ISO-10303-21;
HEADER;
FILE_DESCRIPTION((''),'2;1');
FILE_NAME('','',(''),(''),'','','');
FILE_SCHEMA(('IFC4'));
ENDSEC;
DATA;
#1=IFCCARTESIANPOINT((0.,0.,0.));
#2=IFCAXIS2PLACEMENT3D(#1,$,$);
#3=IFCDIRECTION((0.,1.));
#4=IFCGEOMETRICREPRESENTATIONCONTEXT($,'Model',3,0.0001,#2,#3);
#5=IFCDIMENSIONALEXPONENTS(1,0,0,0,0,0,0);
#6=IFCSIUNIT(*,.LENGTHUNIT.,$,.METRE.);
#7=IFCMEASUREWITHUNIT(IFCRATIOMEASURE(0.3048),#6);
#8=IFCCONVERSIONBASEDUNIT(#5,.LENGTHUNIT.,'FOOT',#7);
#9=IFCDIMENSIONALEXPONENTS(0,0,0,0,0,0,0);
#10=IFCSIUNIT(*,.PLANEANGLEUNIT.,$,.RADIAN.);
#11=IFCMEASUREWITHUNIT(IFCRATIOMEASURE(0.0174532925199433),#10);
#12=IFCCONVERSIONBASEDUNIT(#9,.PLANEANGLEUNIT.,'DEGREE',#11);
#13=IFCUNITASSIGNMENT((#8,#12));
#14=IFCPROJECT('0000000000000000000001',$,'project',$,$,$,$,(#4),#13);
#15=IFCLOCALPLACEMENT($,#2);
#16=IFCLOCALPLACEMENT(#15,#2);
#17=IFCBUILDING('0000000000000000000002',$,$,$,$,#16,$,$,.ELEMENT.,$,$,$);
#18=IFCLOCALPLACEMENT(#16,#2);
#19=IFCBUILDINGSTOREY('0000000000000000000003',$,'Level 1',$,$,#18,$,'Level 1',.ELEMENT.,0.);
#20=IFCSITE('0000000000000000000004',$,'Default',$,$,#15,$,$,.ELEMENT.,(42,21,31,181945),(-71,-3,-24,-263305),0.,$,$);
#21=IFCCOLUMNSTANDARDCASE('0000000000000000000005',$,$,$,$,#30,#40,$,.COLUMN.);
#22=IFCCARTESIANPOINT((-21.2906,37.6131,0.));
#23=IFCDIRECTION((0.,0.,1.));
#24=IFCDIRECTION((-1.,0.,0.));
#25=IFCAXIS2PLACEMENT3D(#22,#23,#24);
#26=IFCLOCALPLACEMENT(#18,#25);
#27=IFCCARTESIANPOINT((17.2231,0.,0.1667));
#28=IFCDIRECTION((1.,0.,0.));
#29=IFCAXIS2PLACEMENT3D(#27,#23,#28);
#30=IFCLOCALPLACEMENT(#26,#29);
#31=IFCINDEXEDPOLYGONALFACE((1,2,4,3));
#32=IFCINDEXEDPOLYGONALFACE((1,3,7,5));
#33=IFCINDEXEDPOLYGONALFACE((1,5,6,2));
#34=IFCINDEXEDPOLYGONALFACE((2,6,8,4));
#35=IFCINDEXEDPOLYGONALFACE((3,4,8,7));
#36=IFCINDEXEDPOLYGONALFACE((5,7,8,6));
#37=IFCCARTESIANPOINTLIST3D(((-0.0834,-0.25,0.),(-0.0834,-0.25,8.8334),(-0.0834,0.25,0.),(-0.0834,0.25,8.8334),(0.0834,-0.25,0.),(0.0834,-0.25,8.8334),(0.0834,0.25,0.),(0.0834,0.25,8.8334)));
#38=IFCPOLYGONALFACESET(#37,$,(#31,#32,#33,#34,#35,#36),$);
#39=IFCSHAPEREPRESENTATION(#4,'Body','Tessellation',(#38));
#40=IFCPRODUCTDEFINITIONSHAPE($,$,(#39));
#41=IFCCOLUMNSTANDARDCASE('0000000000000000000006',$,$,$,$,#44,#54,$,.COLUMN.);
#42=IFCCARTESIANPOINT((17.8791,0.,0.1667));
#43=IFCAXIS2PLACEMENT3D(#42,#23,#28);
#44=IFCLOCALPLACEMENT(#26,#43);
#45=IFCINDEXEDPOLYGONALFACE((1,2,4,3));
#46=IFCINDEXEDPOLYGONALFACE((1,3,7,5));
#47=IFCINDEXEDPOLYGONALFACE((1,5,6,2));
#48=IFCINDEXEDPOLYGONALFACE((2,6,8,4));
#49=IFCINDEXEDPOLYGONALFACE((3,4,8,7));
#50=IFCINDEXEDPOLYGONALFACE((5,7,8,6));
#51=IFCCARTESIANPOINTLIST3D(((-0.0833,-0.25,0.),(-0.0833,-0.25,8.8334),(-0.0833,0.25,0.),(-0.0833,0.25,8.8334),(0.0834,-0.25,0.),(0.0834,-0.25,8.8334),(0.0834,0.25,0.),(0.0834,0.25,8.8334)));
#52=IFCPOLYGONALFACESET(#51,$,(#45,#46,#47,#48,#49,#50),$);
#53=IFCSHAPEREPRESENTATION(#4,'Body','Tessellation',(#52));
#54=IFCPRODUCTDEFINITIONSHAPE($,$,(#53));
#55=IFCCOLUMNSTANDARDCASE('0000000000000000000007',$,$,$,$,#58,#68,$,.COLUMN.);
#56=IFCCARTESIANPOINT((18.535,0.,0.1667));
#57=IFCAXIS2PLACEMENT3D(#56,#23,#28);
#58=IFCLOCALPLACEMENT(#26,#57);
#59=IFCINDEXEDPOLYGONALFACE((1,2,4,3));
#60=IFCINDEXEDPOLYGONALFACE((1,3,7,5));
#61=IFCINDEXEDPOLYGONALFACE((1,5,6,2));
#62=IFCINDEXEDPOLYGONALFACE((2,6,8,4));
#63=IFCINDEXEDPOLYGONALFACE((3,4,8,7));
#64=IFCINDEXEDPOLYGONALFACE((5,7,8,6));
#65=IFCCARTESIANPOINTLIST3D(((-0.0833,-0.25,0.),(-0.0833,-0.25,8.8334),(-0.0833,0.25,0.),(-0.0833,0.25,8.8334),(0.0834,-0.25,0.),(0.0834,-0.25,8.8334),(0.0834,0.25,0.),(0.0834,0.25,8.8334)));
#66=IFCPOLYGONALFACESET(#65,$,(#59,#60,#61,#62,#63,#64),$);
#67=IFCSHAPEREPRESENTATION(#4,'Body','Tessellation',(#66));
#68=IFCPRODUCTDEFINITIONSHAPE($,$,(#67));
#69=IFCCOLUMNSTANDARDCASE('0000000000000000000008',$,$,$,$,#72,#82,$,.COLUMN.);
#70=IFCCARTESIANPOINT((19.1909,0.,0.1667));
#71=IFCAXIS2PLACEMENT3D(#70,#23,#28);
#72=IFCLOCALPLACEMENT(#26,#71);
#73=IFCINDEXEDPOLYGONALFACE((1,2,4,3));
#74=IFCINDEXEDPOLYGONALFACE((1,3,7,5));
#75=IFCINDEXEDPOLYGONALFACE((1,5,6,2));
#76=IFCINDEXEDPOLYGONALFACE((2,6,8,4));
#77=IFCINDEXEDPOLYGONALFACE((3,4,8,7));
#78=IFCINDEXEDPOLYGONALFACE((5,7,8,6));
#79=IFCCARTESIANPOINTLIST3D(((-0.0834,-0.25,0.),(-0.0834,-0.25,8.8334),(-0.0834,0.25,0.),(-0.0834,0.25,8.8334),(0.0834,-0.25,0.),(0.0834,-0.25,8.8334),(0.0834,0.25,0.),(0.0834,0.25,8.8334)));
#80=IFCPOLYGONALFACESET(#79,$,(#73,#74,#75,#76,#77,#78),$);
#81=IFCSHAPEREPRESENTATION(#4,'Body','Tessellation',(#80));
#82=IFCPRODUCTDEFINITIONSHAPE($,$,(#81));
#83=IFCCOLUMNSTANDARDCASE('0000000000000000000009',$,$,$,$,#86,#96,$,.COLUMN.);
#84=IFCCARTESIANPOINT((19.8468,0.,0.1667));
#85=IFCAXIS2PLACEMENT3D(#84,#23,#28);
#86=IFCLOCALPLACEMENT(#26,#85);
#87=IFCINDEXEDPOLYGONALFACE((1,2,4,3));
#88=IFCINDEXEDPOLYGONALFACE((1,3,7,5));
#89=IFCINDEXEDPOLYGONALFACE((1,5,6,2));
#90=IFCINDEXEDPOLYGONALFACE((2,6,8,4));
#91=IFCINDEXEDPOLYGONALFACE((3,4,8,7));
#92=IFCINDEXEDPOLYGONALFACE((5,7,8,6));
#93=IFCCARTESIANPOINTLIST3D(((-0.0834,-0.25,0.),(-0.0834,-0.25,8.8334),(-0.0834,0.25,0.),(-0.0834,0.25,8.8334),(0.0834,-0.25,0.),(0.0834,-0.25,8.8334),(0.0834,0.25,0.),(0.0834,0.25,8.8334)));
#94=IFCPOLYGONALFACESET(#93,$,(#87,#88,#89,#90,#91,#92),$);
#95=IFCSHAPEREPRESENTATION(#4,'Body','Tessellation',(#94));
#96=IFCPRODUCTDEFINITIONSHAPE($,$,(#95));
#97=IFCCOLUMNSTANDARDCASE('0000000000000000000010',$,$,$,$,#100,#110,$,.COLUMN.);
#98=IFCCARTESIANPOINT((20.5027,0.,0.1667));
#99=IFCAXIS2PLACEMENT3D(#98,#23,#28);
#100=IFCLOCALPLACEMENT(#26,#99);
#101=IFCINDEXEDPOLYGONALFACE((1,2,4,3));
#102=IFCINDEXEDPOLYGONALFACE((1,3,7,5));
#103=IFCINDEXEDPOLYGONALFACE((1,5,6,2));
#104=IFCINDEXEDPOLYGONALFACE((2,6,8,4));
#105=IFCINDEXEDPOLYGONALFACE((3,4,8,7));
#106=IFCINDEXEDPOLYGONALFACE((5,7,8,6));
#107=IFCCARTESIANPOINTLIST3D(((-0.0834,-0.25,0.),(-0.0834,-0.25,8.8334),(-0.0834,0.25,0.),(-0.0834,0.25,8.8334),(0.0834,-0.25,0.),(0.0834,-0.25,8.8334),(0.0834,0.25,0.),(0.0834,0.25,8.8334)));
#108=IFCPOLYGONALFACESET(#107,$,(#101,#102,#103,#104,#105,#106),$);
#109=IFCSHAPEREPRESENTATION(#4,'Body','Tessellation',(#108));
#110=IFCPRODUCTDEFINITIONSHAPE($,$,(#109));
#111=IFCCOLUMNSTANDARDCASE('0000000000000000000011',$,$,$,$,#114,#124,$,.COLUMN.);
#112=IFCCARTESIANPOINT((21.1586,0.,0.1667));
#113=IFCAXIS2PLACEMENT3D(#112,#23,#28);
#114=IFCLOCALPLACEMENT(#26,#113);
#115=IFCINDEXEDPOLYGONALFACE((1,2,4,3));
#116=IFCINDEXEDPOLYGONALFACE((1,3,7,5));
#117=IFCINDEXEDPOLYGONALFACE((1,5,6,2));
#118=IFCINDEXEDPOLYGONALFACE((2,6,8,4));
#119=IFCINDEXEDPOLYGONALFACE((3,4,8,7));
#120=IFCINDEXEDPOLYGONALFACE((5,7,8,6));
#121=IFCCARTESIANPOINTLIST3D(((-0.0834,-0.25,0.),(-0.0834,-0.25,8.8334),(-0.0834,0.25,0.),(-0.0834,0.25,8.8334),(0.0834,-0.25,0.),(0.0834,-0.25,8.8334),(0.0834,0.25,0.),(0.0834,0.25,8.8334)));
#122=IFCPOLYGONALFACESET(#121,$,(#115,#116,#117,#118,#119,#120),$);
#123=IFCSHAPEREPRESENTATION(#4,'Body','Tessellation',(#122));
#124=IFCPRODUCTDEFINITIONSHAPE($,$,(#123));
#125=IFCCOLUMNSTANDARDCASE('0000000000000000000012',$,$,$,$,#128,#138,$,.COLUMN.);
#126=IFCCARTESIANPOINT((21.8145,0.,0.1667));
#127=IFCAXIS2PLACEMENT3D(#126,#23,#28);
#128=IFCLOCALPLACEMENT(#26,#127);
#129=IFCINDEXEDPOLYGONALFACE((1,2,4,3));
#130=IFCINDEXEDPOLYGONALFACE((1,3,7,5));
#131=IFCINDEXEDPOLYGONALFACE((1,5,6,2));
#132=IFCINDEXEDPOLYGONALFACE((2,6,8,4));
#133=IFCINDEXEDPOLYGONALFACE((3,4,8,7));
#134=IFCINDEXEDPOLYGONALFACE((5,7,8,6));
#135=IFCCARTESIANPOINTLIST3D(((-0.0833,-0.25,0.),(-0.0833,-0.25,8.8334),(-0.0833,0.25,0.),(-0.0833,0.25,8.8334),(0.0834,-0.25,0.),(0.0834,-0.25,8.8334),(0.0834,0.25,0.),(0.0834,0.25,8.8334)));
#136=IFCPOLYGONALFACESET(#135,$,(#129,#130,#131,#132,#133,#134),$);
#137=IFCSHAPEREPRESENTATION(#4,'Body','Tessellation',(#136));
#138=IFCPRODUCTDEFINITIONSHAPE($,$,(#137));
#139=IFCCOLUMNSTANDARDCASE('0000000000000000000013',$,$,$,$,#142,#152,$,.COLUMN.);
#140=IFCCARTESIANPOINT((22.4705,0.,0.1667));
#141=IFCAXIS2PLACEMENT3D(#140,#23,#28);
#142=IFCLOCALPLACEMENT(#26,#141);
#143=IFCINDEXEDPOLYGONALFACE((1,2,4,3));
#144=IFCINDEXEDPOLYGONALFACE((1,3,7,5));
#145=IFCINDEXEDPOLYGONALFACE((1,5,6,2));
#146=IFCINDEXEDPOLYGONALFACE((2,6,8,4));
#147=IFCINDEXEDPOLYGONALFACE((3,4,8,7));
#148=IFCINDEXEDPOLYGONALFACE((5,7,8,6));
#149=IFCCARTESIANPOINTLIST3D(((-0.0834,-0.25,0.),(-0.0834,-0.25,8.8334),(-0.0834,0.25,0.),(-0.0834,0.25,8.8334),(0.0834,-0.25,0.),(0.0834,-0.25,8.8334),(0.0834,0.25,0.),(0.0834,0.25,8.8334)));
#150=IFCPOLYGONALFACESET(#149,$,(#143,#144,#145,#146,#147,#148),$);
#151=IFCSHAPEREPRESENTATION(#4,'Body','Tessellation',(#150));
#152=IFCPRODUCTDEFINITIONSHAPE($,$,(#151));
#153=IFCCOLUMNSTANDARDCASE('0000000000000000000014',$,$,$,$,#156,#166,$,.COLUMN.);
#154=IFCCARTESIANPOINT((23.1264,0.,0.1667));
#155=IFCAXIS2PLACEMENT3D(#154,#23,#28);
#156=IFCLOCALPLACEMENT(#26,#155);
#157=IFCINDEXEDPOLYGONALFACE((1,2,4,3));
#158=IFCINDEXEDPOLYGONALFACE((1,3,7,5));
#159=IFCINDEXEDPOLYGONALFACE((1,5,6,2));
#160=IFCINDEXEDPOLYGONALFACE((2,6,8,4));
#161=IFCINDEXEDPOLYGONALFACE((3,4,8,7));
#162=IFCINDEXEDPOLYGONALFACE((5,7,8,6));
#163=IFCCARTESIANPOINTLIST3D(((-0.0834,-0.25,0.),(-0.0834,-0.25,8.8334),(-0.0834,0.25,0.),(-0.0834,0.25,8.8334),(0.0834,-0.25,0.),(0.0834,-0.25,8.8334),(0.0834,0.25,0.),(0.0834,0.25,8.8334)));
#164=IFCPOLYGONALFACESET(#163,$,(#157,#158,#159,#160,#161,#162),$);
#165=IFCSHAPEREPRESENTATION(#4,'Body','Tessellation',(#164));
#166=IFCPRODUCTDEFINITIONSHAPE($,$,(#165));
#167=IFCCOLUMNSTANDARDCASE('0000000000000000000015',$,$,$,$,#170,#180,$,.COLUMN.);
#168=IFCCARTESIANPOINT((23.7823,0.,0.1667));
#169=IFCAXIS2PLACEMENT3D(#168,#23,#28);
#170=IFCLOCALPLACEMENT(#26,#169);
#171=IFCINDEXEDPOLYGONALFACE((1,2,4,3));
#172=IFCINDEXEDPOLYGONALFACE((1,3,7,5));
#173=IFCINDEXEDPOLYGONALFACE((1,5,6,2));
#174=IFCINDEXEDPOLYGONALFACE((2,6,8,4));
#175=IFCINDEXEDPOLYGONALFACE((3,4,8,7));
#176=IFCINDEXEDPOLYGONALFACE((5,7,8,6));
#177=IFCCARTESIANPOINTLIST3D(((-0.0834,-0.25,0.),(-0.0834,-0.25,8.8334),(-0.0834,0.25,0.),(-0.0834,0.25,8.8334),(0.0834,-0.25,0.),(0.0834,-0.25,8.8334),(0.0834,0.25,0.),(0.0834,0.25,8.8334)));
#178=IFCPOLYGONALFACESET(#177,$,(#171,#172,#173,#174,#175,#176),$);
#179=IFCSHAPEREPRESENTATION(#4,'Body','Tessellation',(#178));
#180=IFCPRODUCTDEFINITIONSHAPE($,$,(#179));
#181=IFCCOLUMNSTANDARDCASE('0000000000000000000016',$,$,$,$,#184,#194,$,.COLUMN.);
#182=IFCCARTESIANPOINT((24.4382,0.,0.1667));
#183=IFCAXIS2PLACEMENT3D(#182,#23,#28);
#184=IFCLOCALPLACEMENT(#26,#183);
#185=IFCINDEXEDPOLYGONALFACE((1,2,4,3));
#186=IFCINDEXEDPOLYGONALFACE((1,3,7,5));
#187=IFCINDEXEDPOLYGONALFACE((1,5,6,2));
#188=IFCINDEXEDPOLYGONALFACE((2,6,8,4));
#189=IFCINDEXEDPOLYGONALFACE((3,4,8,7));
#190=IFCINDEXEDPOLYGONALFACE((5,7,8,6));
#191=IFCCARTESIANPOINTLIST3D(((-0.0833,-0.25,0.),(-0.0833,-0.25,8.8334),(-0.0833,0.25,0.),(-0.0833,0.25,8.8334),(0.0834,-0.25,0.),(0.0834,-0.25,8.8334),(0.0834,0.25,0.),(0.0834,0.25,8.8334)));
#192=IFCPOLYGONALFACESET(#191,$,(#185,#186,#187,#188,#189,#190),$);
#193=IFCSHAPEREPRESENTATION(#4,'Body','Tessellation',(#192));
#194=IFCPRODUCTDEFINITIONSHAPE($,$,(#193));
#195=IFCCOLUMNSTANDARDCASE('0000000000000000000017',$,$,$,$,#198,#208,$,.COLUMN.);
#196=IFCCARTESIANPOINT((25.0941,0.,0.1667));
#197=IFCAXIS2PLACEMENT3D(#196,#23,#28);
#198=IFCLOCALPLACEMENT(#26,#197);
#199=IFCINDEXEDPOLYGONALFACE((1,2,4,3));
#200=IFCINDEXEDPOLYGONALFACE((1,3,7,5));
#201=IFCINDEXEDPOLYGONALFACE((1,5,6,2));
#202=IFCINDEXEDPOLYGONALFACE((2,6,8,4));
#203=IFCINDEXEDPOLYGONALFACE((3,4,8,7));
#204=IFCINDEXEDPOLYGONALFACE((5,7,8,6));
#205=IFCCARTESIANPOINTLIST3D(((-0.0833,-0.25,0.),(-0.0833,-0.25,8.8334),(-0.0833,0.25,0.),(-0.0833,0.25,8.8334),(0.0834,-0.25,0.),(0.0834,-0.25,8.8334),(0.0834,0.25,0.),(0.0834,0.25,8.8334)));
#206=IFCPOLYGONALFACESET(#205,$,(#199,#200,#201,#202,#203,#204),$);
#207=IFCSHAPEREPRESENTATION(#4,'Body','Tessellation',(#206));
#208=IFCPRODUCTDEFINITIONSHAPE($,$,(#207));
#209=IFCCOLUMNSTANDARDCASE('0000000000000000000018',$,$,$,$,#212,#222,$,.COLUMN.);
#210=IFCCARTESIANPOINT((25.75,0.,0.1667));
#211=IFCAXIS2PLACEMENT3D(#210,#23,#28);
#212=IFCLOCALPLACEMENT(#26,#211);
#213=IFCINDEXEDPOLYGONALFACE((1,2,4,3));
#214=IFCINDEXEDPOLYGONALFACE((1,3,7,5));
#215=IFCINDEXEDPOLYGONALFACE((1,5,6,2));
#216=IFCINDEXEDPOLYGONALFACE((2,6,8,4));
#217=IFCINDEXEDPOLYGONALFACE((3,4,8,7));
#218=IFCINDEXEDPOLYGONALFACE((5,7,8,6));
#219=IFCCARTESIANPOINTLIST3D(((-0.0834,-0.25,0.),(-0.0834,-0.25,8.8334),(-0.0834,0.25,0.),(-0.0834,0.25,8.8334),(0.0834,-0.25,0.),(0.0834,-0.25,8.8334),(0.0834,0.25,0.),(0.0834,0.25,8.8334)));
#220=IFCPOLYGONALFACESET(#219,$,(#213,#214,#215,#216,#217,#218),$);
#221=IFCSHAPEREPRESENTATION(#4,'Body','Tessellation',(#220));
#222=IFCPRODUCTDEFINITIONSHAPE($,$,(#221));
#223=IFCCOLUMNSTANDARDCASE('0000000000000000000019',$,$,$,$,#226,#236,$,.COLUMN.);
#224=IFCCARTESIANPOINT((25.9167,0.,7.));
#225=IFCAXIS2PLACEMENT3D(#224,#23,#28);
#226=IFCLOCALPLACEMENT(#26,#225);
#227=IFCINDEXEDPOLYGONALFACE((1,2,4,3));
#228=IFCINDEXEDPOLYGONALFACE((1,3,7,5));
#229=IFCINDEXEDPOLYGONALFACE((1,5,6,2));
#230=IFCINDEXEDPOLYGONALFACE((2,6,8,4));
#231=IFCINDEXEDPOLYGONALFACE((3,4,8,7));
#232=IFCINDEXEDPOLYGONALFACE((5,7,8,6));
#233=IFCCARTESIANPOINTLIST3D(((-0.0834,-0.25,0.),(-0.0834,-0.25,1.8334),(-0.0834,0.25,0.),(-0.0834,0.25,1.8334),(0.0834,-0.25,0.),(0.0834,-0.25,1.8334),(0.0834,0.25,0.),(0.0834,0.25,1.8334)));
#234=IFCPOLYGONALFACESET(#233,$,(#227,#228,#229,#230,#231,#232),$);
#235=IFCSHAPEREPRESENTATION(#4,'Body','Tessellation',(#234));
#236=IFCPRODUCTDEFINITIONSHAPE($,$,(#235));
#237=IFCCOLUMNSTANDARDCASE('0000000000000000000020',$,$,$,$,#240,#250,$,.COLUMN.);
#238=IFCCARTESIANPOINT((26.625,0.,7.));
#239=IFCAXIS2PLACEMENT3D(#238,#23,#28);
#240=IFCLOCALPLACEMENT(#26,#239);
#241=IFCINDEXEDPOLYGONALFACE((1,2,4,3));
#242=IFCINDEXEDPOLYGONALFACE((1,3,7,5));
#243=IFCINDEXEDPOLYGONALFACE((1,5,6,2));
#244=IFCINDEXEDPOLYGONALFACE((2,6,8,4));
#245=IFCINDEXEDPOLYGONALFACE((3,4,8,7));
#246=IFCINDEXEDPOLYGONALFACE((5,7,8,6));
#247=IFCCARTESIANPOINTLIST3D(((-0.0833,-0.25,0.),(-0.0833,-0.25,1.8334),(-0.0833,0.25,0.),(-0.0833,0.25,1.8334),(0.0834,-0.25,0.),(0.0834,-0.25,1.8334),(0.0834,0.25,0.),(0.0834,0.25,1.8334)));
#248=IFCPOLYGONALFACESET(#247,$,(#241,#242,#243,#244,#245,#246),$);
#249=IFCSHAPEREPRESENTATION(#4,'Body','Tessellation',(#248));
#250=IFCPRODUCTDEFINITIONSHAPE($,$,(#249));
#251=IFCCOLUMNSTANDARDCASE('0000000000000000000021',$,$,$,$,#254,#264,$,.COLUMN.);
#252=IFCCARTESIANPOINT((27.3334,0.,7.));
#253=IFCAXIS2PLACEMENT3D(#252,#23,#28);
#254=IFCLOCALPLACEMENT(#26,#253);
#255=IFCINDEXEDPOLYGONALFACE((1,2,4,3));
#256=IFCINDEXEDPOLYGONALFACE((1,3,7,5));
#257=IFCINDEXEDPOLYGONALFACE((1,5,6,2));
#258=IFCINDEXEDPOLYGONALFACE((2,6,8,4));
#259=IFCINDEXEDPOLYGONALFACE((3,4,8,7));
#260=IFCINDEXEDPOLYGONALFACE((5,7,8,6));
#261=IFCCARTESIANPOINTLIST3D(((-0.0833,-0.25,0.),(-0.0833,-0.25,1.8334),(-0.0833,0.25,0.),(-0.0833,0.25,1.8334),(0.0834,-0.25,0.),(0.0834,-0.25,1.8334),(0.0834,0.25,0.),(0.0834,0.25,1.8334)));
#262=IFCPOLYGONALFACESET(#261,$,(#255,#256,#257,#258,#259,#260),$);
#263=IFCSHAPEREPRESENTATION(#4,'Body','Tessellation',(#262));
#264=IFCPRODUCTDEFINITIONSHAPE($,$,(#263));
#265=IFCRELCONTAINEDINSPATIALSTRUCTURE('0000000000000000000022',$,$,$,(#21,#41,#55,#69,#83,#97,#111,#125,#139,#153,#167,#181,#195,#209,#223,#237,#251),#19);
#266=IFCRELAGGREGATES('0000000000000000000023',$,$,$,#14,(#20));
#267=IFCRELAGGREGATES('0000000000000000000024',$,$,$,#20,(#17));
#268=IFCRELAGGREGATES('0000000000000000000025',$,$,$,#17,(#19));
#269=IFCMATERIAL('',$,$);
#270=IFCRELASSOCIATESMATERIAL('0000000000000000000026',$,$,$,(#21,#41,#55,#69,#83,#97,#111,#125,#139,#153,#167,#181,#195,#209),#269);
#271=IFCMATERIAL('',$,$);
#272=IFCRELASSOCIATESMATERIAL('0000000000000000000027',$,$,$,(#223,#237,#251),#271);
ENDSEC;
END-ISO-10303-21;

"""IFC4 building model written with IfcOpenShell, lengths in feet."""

from ifc_helpers import new_model, entity, si_unit, converted_unit, direction, frame, origin, place, context, project, spatial, rectangle, extrude, material, element, save


model = new_model("IFC4")

# Units and contexts
model_context = context("Model", 3, precision=0.0001, world=origin(), true_north=direction((0.0, 1.0)))
ifc_project = project(units=[converted_unit("LENGTHUNIT", "FOOT", entity("IfcRatioMeasure", 0.3048), si_unit("LENGTHUNIT", "METRE"), dimensions=[1, 0, 0, 0, 0, 0, 0]), converted_unit("PLANEANGLEUNIT", "DEGREE", entity("IfcRatioMeasure", 0.0174532925199433), si_unit("PLANEANGLEUNIT", "RADIAN"), dimensions=[0, 0, 0, 0, 0, 0, 0])], contexts=[model_context])

# Site, building, storey
site_placement = place(None, origin())
site = spatial("IfcSite", under=ifc_project, at=site_placement, Name="Default", CompositionType="ELEMENT", RefLatitude=(42, 21, 31, 181945), RefLongitude=(-71, -3, -24, -263305), RefElevation=0.0)
building_placement = place(site_placement, origin())
building = spatial("IfcBuilding", under=site, at=building_placement, CompositionType="ELEMENT")
storey_placement = place(building_placement, origin())
storey = spatial("IfcBuildingStorey", under=building, at=storey_placement, Name="Level 1", LongName="Level 1", CompositionType="ELEMENT", Elevation=0.0)

# Columns
ifc_material_1 = material(Name="")
ifc_material_2 = material(Name="")
placement_1 = place(storey_placement, frame((-21.2906, 37.6131, 0.0), z_axis=(0.0, 0.0, 1.0), x_axis=(-1.0, 0.0, 0.0)))
for number, where, z_axis, x_axis in (
    (1, (17.2231, 0.0, 0.1667), (0.0, 0.0, 1.0), (1.0, 0.0, 0.0)),
    (2, (17.8791, 0.0, 0.1667), (0.0, 0.0, 1.0), (1.0, 0.0, 0.0)),
    (3, (18.535, 0.0, 0.1667), (0.0, 0.0, 1.0), (1.0, 0.0, 0.0)),
    (4, (19.1909, 0.0, 0.1667), (0.0, 0.0, 1.0), (1.0, 0.0, 0.0)),
    (5, (19.8468, 0.0, 0.1667), (0.0, 0.0, 1.0), (1.0, 0.0, 0.0)),
    (6, (20.5027, 0.0, 0.1667), (0.0, 0.0, 1.0), (1.0, 0.0, 0.0)),
    (7, (21.1586, 0.0, 0.1667), (0.0, 0.0, 1.0), (1.0, 0.0, 0.0)),
    (8, (21.8145, 0.0, 0.1667), (0.0, 0.0, 1.0), (1.0, 0.0, 0.0)),
    (9, (22.4705, 0.0, 0.1667), (0.0, 0.0, 1.0), (1.0, 0.0, 0.0)),
    (10, (23.1264, 0.0, 0.1667), (0.0, 0.0, 1.0), (1.0, 0.0, 0.0)),
    (11, (23.7823, 0.0, 0.1667), (0.0, 0.0, 1.0), (1.0, 0.0, 0.0)),
    (12, (24.4382, 0.0, 0.1667), (0.0, 0.0, 1.0), (1.0, 0.0, 0.0)),
    (13, (25.0941, 0.0, 0.1667), (0.0, 0.0, 1.0), (1.0, 0.0, 0.0)),
    (14, (25.75, 0.0, 0.1667), (0.0, 0.0, 1.0), (1.0, 0.0, 0.0)),
):
    element("IfcColumnStandardCase", number, at=place(placement_1, frame(where, z_axis=z_axis, x_axis=x_axis)), inside=storey, material=ifc_material_1, PredefinedType="COLUMN", context=model_context, shape_type="SweptSolid", body=[
        extrude(rectangle(XDim=0.1667, YDim=0.5), origin(), (0.0, 0.0, 1.0), 8.8334),
    ])
for number, where, z_axis, x_axis in (
    (15, (25.9167, 0.0, 7.0), (0.0, 0.0, 1.0), (1.0, 0.0, 0.0)),
    (16, (26.625, 0.0, 7.0), (0.0, 0.0, 1.0), (1.0, 0.0, 0.0)),
    (17, (27.3334, 0.0, 7.0), (0.0, 0.0, 1.0), (1.0, 0.0, 0.0)),
):
    element("IfcColumnStandardCase", number, at=place(placement_1, frame(where, z_axis=z_axis, x_axis=x_axis)), inside=storey, material=ifc_material_2, PredefinedType="COLUMN", context=model_context, shape_type="SweptSolid", body=[
        extrude(rectangle(XDim=0.1667, YDim=0.5), origin(), (0.0, 0.0, 1.0), 1.8334),
    ])

save(model, "model.ifc")
